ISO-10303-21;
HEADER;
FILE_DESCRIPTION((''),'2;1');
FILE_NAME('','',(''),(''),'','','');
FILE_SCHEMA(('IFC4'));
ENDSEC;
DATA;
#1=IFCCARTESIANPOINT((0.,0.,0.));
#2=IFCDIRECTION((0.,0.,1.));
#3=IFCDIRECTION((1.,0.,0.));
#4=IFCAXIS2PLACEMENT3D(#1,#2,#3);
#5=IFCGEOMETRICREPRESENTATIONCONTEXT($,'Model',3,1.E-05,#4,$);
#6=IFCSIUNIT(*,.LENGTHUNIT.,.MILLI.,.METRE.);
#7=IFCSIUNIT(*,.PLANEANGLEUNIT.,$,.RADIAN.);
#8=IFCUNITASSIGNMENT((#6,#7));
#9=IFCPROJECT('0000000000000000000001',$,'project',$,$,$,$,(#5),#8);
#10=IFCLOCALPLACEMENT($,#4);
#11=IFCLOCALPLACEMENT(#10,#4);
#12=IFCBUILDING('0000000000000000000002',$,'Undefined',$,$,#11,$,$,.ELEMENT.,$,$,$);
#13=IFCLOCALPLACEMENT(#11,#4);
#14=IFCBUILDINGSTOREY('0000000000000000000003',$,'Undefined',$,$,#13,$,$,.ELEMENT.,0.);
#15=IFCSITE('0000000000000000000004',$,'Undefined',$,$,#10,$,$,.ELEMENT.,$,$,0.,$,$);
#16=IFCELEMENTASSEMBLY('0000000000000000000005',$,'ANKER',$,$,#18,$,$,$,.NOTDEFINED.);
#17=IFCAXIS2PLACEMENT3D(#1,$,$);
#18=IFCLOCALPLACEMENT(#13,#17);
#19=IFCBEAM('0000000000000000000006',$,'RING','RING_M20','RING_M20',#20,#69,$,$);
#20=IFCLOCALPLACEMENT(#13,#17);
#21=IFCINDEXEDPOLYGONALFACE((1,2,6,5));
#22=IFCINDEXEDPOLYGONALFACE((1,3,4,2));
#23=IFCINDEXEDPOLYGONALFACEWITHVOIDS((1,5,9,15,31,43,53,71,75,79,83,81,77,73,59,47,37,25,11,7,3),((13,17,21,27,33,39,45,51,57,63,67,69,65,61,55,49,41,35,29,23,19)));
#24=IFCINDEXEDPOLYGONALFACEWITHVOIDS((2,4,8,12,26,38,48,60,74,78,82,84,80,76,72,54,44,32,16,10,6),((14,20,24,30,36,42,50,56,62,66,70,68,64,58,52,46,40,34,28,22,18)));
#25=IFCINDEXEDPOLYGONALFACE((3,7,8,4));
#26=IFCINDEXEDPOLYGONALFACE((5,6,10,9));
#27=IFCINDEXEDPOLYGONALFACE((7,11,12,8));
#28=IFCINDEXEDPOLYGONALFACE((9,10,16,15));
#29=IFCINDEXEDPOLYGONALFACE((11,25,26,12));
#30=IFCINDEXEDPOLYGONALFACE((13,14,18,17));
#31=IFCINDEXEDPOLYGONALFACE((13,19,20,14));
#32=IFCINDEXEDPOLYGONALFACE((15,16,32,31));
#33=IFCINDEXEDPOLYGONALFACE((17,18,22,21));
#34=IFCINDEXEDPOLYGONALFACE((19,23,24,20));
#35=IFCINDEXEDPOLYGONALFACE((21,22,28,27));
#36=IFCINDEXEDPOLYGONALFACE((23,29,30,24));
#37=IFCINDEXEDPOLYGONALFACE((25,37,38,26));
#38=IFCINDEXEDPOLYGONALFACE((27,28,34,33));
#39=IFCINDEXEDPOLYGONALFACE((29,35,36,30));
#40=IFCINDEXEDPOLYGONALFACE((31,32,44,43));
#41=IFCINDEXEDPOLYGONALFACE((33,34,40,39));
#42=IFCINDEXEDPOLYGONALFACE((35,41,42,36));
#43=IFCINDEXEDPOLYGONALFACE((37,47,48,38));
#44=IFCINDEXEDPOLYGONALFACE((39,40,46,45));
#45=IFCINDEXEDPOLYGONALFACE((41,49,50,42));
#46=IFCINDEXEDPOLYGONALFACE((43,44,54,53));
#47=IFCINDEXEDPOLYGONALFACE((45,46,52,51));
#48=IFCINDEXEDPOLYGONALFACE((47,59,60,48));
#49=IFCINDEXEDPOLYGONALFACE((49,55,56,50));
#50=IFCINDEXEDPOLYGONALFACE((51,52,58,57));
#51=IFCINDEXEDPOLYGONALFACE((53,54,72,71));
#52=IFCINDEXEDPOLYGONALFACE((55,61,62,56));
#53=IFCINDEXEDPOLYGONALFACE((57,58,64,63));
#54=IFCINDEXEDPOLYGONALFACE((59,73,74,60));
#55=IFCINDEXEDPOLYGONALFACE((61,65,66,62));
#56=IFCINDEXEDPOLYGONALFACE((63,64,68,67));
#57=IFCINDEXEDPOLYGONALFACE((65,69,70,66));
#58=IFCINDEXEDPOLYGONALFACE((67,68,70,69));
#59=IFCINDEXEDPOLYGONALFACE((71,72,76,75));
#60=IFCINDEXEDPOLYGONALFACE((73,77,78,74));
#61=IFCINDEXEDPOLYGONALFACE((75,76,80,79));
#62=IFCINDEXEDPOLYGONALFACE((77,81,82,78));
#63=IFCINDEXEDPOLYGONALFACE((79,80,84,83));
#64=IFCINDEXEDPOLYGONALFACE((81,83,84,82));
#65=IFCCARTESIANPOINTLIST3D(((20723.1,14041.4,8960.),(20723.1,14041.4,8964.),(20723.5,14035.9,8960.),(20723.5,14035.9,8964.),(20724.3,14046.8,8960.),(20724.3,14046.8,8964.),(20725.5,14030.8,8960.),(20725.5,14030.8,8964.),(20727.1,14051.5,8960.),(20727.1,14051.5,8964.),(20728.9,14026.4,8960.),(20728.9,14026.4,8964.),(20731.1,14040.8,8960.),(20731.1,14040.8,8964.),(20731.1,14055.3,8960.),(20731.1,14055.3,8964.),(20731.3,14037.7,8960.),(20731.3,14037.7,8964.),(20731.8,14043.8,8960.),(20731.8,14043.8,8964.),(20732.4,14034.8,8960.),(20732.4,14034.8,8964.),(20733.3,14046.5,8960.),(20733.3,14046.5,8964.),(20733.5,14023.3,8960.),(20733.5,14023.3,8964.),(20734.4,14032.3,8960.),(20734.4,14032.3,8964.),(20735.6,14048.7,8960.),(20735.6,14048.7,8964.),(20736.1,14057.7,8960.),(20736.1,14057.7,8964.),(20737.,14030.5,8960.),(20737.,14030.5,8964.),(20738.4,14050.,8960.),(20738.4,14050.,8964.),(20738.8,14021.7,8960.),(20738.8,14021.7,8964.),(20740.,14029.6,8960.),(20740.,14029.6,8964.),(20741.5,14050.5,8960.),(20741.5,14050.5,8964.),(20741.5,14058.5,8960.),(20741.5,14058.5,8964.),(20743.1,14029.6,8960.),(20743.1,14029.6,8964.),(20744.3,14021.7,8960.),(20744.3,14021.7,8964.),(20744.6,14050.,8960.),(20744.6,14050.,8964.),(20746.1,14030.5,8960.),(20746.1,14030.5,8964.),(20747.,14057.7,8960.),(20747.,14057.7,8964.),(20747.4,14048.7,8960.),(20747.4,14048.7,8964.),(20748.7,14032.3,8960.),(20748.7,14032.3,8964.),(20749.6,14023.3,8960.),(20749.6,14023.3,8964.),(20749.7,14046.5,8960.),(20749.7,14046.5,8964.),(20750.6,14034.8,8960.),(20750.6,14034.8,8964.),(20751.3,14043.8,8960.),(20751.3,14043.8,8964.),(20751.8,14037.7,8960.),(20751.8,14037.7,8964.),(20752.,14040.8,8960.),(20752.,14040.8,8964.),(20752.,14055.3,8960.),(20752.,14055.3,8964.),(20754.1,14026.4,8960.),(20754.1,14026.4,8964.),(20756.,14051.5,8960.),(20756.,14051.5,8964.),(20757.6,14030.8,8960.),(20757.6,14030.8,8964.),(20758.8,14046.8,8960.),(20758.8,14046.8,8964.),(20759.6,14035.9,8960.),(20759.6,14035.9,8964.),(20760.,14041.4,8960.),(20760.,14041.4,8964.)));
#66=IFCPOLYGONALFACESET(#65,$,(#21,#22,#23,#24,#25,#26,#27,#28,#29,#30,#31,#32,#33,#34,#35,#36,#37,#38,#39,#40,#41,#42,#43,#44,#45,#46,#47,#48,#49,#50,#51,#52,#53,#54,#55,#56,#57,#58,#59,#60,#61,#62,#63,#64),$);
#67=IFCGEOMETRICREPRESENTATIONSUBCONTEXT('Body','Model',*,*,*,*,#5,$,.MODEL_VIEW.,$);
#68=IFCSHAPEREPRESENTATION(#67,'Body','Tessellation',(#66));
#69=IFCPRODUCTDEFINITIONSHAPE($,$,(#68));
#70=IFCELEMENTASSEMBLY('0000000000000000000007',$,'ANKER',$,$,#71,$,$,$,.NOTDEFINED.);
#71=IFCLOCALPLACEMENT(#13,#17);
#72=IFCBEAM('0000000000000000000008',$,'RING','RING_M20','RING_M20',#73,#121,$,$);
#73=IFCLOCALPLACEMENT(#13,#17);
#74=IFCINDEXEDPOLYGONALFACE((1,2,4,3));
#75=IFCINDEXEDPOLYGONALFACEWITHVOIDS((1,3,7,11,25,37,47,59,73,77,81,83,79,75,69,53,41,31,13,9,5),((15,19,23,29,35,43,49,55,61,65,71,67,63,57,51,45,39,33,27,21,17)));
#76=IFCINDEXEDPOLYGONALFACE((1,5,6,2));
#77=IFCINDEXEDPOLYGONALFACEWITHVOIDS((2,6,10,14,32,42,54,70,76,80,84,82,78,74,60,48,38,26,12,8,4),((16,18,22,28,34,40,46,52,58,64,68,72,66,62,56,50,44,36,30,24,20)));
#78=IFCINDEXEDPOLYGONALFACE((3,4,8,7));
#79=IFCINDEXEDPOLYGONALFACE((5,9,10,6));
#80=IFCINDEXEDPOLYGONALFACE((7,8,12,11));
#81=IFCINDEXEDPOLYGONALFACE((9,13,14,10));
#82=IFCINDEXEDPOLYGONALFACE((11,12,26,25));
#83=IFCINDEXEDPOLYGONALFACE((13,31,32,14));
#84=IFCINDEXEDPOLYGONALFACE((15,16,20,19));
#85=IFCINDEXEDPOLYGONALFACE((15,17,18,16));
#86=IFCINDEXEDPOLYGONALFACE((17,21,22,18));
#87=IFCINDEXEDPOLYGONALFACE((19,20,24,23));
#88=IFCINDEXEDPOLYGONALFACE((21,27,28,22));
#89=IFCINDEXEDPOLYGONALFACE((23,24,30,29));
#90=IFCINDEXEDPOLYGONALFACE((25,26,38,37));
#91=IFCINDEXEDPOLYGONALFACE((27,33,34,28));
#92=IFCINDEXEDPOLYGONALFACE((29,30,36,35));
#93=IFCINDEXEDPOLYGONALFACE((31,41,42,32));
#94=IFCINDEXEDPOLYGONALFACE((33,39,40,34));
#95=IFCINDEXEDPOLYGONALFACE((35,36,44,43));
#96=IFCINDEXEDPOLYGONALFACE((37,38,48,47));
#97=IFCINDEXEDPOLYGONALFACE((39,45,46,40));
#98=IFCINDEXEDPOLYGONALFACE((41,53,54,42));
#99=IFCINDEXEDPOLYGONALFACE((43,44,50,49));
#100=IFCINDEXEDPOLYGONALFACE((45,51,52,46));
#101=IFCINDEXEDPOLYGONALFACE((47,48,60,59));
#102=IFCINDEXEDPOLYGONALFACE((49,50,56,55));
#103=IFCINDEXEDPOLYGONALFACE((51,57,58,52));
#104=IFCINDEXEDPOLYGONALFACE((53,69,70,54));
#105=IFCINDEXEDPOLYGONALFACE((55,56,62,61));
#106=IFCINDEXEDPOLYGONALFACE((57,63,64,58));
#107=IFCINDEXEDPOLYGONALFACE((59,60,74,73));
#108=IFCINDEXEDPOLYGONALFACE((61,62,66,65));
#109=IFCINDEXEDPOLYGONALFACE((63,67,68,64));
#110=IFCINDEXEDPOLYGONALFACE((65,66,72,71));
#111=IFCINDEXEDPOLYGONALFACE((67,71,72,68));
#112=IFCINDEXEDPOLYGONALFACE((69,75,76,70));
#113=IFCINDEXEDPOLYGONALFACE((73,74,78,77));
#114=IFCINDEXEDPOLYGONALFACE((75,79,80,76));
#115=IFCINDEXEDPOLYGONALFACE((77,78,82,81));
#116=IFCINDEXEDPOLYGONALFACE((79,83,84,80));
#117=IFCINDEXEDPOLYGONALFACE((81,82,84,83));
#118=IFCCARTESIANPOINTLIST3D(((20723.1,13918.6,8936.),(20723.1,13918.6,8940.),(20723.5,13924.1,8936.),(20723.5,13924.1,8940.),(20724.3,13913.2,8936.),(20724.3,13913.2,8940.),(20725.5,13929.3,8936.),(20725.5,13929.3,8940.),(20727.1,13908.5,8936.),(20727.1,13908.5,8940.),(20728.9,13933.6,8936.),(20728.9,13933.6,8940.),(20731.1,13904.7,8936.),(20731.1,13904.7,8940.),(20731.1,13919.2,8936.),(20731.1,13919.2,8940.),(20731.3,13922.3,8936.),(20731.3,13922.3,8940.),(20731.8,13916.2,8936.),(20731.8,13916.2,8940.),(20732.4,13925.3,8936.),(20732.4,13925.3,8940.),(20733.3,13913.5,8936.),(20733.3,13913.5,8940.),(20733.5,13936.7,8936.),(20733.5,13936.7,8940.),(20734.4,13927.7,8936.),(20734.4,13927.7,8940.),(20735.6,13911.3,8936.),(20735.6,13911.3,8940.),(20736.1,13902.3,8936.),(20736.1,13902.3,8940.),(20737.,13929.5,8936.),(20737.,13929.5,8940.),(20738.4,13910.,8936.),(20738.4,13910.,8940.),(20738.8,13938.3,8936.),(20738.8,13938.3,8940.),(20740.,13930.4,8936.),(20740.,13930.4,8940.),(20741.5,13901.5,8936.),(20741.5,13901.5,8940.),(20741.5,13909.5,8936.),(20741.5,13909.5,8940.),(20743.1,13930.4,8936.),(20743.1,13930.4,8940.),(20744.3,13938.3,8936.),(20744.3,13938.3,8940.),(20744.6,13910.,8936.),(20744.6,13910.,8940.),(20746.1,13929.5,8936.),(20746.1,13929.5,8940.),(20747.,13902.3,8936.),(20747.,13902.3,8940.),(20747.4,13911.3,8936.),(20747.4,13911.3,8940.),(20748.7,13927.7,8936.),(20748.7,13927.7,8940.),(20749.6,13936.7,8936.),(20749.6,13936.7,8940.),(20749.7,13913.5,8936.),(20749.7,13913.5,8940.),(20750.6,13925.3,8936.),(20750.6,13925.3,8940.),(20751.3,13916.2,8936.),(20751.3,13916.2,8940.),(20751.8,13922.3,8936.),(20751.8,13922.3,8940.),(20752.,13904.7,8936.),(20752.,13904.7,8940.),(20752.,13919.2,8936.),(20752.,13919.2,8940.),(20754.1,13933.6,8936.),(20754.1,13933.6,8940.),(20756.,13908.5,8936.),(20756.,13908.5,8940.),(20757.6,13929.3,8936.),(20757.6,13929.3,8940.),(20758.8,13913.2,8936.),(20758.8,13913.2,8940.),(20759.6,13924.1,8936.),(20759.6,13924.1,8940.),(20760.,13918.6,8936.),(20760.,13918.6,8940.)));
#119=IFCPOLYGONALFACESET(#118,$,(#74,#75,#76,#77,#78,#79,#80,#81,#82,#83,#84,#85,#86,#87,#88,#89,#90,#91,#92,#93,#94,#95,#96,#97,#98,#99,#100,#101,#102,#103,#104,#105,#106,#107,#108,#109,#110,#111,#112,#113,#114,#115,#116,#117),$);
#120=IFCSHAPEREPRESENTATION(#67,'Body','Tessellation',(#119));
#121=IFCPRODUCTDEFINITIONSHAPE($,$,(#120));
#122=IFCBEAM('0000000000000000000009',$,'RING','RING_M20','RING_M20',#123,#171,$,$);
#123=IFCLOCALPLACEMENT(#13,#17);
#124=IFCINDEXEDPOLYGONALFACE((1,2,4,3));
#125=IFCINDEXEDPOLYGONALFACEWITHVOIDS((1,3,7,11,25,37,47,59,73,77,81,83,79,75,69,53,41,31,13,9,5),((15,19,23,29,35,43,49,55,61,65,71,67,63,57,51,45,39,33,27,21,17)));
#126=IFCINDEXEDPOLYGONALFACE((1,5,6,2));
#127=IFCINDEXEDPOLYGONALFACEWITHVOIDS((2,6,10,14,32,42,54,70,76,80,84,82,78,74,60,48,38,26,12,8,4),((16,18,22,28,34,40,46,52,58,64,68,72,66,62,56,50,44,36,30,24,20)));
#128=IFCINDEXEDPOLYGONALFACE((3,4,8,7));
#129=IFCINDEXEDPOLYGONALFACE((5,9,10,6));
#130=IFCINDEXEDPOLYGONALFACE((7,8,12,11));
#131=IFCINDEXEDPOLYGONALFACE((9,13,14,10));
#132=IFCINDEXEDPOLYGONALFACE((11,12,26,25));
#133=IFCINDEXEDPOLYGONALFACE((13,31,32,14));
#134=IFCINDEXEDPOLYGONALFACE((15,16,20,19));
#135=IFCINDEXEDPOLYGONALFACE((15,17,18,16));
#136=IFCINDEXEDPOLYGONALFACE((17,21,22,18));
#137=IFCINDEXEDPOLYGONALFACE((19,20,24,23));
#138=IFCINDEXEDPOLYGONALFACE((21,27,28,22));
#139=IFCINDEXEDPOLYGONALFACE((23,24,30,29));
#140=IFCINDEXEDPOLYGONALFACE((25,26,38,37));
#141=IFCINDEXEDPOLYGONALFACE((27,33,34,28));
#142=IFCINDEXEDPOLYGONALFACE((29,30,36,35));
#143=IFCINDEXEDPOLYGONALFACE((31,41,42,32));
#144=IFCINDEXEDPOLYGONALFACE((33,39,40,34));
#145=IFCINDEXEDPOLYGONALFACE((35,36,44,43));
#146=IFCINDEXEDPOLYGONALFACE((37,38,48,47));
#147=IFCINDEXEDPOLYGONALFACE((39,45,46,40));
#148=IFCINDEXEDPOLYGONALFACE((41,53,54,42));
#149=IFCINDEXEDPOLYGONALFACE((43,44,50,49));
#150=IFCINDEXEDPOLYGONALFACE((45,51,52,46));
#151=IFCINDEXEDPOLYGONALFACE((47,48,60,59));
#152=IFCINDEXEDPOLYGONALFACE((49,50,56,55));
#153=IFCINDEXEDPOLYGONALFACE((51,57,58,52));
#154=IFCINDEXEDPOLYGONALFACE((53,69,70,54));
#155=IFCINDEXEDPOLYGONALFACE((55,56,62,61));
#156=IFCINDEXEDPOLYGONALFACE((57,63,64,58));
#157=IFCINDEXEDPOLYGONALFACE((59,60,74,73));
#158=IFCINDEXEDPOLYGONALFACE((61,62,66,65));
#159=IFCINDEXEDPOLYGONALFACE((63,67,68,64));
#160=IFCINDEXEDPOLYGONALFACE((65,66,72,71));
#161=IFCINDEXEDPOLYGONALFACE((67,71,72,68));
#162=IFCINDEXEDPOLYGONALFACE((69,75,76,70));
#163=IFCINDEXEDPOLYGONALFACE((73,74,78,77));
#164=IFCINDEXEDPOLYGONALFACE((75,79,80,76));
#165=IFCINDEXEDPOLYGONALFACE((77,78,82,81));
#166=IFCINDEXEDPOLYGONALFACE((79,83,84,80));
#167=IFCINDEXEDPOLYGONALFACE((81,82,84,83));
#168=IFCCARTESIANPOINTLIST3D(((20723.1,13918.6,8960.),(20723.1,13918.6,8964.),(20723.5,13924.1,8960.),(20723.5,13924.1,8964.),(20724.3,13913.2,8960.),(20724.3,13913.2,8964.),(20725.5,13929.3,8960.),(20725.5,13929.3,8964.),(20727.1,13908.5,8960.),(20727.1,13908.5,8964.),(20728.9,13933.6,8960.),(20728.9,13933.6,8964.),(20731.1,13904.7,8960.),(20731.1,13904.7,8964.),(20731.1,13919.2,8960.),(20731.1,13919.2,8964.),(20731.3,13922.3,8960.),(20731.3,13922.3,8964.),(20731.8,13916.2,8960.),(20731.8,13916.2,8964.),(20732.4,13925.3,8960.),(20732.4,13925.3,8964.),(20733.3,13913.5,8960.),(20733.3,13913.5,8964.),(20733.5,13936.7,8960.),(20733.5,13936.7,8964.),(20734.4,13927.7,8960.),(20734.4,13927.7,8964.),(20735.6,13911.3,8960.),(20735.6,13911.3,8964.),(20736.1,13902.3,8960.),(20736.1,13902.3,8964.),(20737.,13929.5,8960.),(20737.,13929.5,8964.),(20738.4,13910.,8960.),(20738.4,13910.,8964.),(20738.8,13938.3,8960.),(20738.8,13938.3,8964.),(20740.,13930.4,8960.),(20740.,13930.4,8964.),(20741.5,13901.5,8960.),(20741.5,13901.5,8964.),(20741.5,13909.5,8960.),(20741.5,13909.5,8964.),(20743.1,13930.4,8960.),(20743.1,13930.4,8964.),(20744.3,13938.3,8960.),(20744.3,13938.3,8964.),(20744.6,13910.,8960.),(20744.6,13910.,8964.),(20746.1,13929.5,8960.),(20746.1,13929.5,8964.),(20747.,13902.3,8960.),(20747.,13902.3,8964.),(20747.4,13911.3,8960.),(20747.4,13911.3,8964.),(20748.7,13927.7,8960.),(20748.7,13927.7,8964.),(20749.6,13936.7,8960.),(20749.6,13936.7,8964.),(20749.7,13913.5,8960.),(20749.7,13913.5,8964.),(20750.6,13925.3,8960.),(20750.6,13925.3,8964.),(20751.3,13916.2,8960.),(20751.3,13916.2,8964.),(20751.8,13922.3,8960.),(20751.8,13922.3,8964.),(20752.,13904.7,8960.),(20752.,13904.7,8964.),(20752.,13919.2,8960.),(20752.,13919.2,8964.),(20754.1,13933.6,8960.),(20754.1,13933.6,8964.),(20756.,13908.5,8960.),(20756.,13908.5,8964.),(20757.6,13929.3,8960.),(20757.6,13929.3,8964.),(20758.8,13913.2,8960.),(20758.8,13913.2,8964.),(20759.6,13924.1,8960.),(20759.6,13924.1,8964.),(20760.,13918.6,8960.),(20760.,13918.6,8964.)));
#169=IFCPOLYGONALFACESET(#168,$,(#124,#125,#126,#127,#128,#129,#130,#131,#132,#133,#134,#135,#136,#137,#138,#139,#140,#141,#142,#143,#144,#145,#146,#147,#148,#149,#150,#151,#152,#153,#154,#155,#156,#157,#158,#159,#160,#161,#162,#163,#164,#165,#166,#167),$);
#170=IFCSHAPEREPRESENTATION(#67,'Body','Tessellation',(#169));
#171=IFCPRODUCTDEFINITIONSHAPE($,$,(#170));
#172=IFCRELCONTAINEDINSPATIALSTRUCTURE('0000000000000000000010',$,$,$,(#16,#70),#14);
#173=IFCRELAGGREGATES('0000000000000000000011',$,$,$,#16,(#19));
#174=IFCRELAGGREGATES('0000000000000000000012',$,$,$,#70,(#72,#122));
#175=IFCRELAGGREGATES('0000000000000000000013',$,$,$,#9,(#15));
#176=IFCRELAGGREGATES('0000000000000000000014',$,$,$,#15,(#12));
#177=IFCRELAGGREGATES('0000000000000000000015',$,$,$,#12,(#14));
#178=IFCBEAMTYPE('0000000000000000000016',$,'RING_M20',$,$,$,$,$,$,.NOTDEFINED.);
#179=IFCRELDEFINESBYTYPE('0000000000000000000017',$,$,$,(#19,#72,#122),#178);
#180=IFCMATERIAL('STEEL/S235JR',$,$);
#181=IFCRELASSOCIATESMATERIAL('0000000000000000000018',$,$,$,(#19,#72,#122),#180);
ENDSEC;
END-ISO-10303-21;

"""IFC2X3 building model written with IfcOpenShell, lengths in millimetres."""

from ifc_helpers import new_model, si_unit, frame, origin_with_axes, origin_2d_with_axis, place, context, subcontext, project, spatial, hollow_circle, extrude, material, type_object, element, aggregate, save


model = new_model("IFC2X3")

# Units and contexts
model_context = context("Model", 3, precision=1e-05, world=origin_with_axes())
body_context = subcontext(model_context, "Body", "Model", "MODEL_VIEW")
ifc_project = project(units=[si_unit("LENGTHUNIT", "METRE", prefix="MILLI"), si_unit("PLANEANGLEUNIT", "RADIAN")], contexts=[model_context])

# Site, building, storey
site_placement = place(None, origin_with_axes())
site = spatial("IfcSite", under=ifc_project, at=site_placement, Name="Undefined", CompositionType="ELEMENT", RefElevation=0.0)
building_placement = place(site_placement, origin_with_axes())
building = spatial("IfcBuilding", under=site, at=building_placement, Name="Undefined", CompositionType="ELEMENT")
storey_placement = place(building_placement, origin_with_axes())
storey = spatial("IfcBuildingStorey", under=building, at=storey_placement, Name="Undefined", CompositionType="ELEMENT", Elevation=0.0)

# Shared definitions
ifc_material = material(Name="STEEL/S235JR")

# Element assemblies, beams
assembly_1_placement = place(storey_placement, frame((20741.5, 14040.0, 9010.0), z_axis=(0.0, 1.0, 0.0), x_axis=(0.0, 0.0, -1.0)))
assembly_1 = element("IfcElementAssembly", 1, at=assembly_1_placement, inside=storey, Name="ANKER", PredefinedType="NOTDEFINED")
beam_type_1 = type_object("IfcBeamType", Name="RING_M20", PredefinedType="NOTDEFINED")
beam_1_placement = place(storey_placement, frame((20741.5, 14040.0, 8964.0), z_axis=(-1.0, 0.0, 0.0), x_axis=(0.0, 0.0, -1.0)))
beam_1 = element("IfcBeam", 2, at=beam_1_placement, type_object=beam_type_1, material=ifc_material, Name="RING", Description="RING_M20", ObjectType="RING_M20", context=body_context, shape_type="SweptSolid", body=[
    extrude(hollow_circle(Radius=18.5, WallThickness=8.0, at=origin_2d_with_axis()), frame((4.0, 0.0, 0.0), z_axis=(-1.0, 0.0, 0.0), x_axis=(0.0, -1.0, 0.0)), (0.0, 0.0, 1.0), 4.0),
])
aggregate(assembly_1, [beam_1])
assembly_2_placement = place(storey_placement, frame((20741.5, 13920.0, 9010.0), z_axis=(0.0, 1.0, 0.0), x_axis=(0.0, 0.0, -1.0)))
assembly_2 = element("IfcElementAssembly", 3, at=assembly_2_placement, inside=storey, Name="ANKER", PredefinedType="NOTDEFINED")
beam_2_placement = place(storey_placement, frame((20741.5, 13920.0, 8940.0), z_axis=(1.0, 0.0, 0.0), x_axis=(0.0, 0.0, -1.0)))
beam_2 = element("IfcBeam", 4, at=beam_2_placement, type_object=beam_type_1, material=ifc_material, Name="RING", Description="RING_M20", ObjectType="RING_M20", context=body_context, shape_type="SweptSolid", body=[
    extrude(hollow_circle(Radius=18.5, WallThickness=8.0, at=origin_2d_with_axis()), frame((4.0, 0.0, 0.0), z_axis=(-1.0, 0.0, 0.0), x_axis=(0.0, -1.0, 0.0)), (0.0, 0.0, 1.0), 4.0),
])
beam_3_placement = place(storey_placement, frame((20741.5, 13920.0, 8964.0), z_axis=(1.0, 0.0, 0.0), x_axis=(0.0, 0.0, -1.0)))
beam_3 = element("IfcBeam", 5, at=beam_3_placement, type_object=beam_type_1, material=ifc_material, Name="RING", Description="RING_M20", ObjectType="RING_M20", context=body_context, shape_type="SweptSolid", body=[
    extrude(hollow_circle(Radius=18.5, WallThickness=8.0, at=origin_2d_with_axis()), frame((4.0, 0.0, 0.0), z_axis=(-1.0, 0.0, 0.0), x_axis=(0.0, -1.0, 0.0)), (0.0, 0.0, 1.0), 4.0),
])
aggregate(assembly_2, [beam_2, beam_3])

save(model, "model.ifc")
